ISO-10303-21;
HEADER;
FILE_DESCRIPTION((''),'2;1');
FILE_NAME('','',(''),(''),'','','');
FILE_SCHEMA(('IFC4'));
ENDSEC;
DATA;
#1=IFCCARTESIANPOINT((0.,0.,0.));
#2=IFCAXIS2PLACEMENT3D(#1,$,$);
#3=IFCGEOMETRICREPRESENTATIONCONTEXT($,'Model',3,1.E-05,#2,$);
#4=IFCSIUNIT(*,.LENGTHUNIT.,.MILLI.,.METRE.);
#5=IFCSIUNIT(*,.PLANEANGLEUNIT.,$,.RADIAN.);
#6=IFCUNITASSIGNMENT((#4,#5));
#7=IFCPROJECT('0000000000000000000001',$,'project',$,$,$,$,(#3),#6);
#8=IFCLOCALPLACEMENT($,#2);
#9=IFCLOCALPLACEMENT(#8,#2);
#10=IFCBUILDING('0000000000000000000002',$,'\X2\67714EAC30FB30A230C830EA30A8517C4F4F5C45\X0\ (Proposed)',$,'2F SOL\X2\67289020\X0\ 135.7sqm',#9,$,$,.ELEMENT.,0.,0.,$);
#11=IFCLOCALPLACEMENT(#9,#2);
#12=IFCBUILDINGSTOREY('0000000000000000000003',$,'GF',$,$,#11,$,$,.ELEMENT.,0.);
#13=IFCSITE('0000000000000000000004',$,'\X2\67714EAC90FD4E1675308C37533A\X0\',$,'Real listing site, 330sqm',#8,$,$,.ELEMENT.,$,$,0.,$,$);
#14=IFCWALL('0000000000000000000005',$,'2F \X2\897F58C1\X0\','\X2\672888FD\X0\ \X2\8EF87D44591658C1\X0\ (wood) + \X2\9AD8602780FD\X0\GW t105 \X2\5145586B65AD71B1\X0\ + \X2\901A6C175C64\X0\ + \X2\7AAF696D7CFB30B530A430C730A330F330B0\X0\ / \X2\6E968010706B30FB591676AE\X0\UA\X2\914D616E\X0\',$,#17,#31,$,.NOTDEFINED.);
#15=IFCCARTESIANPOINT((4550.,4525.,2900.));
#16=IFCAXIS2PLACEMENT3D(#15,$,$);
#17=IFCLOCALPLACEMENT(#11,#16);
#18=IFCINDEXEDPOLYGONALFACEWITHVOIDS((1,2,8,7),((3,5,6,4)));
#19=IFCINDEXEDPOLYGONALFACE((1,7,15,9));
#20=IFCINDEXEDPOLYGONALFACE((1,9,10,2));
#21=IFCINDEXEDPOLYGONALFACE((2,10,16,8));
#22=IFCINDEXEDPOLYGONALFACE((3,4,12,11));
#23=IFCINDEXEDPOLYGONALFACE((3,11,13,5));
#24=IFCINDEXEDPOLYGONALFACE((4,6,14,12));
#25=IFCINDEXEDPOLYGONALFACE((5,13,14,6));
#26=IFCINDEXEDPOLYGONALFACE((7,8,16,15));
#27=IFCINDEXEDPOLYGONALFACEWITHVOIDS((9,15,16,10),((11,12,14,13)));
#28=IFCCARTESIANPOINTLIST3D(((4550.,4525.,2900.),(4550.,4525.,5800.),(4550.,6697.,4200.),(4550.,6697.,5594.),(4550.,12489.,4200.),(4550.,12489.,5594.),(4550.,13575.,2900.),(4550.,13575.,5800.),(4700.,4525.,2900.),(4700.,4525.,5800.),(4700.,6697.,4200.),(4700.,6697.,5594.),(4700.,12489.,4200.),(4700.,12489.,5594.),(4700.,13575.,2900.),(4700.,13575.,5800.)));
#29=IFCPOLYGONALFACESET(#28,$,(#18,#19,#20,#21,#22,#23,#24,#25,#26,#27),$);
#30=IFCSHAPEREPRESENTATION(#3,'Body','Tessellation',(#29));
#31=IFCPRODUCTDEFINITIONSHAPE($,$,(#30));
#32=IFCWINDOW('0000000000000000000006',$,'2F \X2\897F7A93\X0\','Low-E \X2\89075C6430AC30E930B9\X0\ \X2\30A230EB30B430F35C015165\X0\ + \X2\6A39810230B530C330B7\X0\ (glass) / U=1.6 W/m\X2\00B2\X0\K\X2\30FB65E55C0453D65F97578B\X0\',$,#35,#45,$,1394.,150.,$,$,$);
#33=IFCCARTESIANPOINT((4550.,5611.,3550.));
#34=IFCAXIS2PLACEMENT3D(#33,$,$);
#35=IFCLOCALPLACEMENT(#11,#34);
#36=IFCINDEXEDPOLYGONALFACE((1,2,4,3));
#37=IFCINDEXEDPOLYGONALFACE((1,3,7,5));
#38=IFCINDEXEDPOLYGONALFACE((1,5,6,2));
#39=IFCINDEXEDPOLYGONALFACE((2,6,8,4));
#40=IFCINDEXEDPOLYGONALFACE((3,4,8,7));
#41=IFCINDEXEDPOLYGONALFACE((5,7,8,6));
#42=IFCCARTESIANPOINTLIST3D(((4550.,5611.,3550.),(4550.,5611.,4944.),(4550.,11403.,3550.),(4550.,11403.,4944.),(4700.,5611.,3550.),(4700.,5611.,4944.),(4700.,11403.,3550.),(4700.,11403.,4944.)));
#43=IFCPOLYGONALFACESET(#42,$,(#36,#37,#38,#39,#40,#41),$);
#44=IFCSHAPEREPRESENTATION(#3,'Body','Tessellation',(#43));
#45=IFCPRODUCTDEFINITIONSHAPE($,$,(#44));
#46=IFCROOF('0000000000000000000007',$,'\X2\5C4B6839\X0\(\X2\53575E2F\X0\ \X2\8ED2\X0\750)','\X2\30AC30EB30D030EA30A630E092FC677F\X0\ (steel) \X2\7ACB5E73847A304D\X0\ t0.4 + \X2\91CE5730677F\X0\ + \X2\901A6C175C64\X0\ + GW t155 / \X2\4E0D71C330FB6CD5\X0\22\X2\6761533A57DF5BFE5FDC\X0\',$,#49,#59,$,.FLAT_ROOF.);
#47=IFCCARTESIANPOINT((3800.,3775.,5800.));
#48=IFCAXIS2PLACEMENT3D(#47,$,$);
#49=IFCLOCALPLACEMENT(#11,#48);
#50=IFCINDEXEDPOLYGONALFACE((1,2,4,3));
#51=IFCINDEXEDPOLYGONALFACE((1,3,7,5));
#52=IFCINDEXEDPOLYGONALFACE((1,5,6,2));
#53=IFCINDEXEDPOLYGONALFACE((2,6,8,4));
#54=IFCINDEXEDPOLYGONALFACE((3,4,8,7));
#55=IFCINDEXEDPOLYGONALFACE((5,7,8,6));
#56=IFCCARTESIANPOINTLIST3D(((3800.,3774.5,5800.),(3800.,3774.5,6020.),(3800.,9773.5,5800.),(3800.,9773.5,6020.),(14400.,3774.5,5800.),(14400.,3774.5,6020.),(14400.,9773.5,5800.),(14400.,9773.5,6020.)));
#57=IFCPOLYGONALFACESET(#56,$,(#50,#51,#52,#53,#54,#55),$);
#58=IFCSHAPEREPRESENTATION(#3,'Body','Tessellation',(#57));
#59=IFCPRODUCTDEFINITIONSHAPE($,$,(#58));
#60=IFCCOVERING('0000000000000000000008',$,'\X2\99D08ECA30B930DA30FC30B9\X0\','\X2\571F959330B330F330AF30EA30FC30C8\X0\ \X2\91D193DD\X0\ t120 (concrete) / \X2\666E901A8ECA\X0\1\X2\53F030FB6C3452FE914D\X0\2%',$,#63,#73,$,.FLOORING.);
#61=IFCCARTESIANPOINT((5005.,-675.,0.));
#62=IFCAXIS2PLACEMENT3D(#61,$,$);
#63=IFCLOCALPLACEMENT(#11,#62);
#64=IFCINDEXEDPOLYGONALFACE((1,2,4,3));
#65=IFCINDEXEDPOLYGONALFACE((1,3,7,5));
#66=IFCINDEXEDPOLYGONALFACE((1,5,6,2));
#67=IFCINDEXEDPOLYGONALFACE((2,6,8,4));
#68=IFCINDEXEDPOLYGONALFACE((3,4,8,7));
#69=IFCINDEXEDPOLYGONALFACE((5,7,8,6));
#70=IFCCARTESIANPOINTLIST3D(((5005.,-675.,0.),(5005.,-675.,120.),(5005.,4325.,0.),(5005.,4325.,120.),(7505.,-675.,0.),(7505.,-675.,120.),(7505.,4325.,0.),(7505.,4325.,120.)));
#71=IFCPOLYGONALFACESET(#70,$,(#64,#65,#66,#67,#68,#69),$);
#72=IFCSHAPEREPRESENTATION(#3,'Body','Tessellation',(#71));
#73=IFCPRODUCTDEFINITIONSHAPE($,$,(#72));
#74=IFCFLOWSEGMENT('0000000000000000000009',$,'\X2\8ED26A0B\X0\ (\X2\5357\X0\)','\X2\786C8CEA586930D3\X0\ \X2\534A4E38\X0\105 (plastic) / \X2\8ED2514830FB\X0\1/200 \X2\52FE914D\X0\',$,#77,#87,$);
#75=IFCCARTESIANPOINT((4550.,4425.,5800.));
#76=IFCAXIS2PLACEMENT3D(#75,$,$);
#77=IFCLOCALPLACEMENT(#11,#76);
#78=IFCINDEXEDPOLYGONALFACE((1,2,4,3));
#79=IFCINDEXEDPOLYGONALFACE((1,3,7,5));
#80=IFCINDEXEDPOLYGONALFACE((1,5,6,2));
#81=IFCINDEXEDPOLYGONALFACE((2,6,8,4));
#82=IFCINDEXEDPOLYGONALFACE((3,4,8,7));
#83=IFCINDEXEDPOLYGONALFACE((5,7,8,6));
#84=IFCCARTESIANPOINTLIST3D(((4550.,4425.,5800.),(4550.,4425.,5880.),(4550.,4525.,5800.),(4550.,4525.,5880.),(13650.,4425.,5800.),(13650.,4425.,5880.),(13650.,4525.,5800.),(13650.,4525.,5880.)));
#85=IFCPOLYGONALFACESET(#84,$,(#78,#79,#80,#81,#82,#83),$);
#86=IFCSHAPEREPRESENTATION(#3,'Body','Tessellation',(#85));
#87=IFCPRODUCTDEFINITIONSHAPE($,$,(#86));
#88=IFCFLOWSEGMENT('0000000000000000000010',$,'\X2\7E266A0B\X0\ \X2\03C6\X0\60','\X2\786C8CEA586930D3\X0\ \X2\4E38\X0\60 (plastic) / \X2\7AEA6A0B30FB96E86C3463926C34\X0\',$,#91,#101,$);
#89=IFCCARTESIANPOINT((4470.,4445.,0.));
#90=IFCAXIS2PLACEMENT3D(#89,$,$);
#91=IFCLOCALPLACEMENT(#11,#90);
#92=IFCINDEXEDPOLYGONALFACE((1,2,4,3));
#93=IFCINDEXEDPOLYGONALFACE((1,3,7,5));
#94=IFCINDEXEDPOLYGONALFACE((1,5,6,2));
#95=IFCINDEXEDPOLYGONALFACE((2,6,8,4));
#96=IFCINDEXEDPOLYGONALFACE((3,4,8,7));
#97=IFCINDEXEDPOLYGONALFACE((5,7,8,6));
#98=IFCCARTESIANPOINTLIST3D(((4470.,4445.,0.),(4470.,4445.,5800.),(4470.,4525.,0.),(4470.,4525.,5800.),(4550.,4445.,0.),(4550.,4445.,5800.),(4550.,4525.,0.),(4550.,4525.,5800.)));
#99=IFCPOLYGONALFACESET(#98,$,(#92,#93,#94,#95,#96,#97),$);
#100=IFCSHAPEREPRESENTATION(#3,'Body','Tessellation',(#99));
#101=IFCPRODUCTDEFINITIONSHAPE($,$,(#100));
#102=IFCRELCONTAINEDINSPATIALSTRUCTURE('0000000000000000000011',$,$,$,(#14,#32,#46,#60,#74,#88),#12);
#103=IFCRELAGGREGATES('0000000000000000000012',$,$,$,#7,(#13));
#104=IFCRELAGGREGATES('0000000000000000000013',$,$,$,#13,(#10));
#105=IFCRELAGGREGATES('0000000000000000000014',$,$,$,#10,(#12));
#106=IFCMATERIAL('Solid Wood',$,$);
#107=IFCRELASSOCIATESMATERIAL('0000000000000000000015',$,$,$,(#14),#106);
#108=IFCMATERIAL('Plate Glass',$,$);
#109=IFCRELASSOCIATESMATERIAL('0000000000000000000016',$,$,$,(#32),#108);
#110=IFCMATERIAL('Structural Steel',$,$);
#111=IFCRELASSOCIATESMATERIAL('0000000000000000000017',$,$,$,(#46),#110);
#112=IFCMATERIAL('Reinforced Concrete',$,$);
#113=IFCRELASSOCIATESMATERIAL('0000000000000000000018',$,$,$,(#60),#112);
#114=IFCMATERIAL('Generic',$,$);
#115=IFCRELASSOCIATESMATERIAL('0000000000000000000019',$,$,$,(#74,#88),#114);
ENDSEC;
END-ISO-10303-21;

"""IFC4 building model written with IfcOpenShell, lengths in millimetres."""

from ifc_helpers import new_model, si_unit, frame, frame_2d, origin, place, context, project, spatial, rectangle, extrude, material, element, fill, save


model = new_model("IFC4")

# Units and contexts
model_context = context("Model", 3, precision=1e-05, world=origin())
ifc_project = project(units=[si_unit("LENGTHUNIT", "METRE", prefix="MILLI"), si_unit("PLANEANGLEUNIT", "RADIAN")], contexts=[model_context])

# Site, building, storey
site_placement = place(None, origin())
site = spatial("IfcSite", under=ifc_project, at=site_placement, Name="東京都世田谷区", ObjectType="Real listing site, 330sqm", CompositionType="ELEMENT", RefElevation=0.0)
building_placement = place(site_placement, origin())
building = spatial("IfcBuilding", under=site, at=building_placement, Name="東京・アトリエ兼住居 (Proposed)", ObjectType="2F SOL木造 135.7sqm", CompositionType="ELEMENT", ElevationOfRefHeight=0.0, ElevationOfTerrain=0.0)
storey_placement = place(building_placement, origin())
storey = spatial("IfcBuildingStorey", under=building, at=storey_placement, Name="GF", CompositionType="ELEMENT", Elevation=0.0)

# Shared definitions
ifc_material_1 = material(Name="Solid Wood")

# Shared definitions
ifc_material_2 = material(Name="Reinforced Concrete")

# Shared definitions
ifc_material_3 = material(Name="Plate Glass")

# Wall, opening, window
wall_1_placement = place(storey_placement, frame((4550.0, 4525.0, 2900.0)))
wall_1 = element("IfcWall", 1, at=wall_1_placement, inside=storey, material=ifc_material_1, Name="2F 西壁", Description="木製 軸組外壁 (wood) + 高性能GW t105 充填断熱 + 通気層 + 窯業系サイディング / 準耐火・外皮UA配慮", PredefinedType="NOTDEFINED", context=model_context, shape_type="SweptSolid", body=[
    extrude(rectangle(XDim=150.0, YDim=9050.0, at=frame_2d((75.0, 4525.0))), frame((4550.0, 4525.0, 2900.0)), (0.0, 0.0, 1.0), 2900.0),
])
opening_1_placement = place(storey_placement, frame((4550.0, 5611.0, 3550.0)))
opening_1 = element("IfcOpeningElement", 2, at=opening_1_placement, cuts=wall_1, PredefinedType="NOTDEFINED", context=model_context, shape_type="SweptSolid", body=[
    extrude(rectangle(XDim=150.0, YDim=5792.0, at=frame_2d((75.0, 2896.0))), frame((4550.0, 5611.0, 3550.0)), (0.0, 0.0, 1.0), 1394.0),
])
window_1_placement = place(storey_placement, frame((4550.0, 5611.0, 3550.0)))
window_1 = element("IfcWindow", 3, at=window_1_placement, inside=storey, material=ifc_material_3, Name="2F 西窓", Description="Low-E 複層ガラス アルゴン封入 + 樹脂サッシ (glass) / U=1.6 W/m²K・日射取得型", OverallHeight=1394.0, OverallWidth=150.0, context=model_context, shape_type="SweptSolid", body=[
    extrude(rectangle(XDim=150.0, YDim=5792.0, at=frame_2d((75.0, 2896.0))), frame((4550.0, 5611.0, 3550.0)), (0.0, 0.0, 1.0), 1394.0),
])
fill(opening_1, window_1)

# Roof
ifc_material_4 = material(Name="Structural Steel")
for number, where, name in (
    (4, (3800.0, 3775.0, 5800.0), "屋根(南帯 軒750)"),
):
    element("IfcRoof", number, at=place(storey_placement, frame(where)), inside=storey, material=ifc_material_4, Name=name, Description="ガルバリウム鋼板 (steel) 立平葺き t0.4 + 野地板 + 通気層 + GW t155 / 不燃・法22条区域対応", PredefinedType="FLAT_ROOF", context=model_context, shape_type="SweptSolid", body=[
        extrude(rectangle(XDim=10600.0, YDim=5999.0, at=frame_2d((5300.0, 2999.0))), frame((3800.0, 3775.0, 5800.0)), (0.0, 0.0, 1.0), 220.0),
    ])

# Covering
covering_placement = place(storey_placement, frame((5005.0, -675.0, 0.0)))
element("IfcCovering", 5, at=covering_placement, inside=storey, material=ifc_material_2, Name="駐車スペース", Description="土間コンクリート 金鏝 t120 (concrete) / 普通車1台・水勾配2%", PredefinedType="FLOORING", context=model_context, shape_type="SweptSolid", body=[
    extrude(rectangle(XDim=2500.0, YDim=5000.0, at=frame_2d((1250.0, 2500.0))), frame((5005.0, -675.0, 0.0)), (0.0, 0.0, 1.0), 120.0),
])

# Flow segments
ifc_material_5 = material(Name="Generic")
flow_segment_1_placement = place(storey_placement, frame((4550.0, 4425.0, 5800.0)))
element("IfcFlowSegment", 6, at=flow_segment_1_placement, inside=storey, material=ifc_material_5, Name="軒樋 (南)", Description="硬質塩ビ 半丸105 (plastic) / 軒先・1/200 勾配", context=model_context, shape_type="SweptSolid", body=[
    extrude(rectangle(XDim=9100.0, YDim=100.0, at=frame_2d((4550.0, 50.0))), frame((4550.0, 4425.0, 5800.0)), (0.0, 0.0, 1.0), 80.0),
])
flow_segment_2_placement = place(storey_placement, frame((4470.0, 4445.0, 0.0)))
element("IfcFlowSegment", 7, at=flow_segment_2_placement, inside=storey, material=ifc_material_5, Name="縦樋 φ60", Description="硬質塩ビ 丸60 (plastic) / 竪樋・雨水排水", context=model_context, shape_type="SweptSolid", body=[
    extrude(rectangle(XDim=80.0, YDim=80.0, at=frame_2d((40.0, 40.0))), frame((4470.0, 4445.0, 0.0)), (0.0, 0.0, 1.0), 5800.0),
])

save(model, "model.ifc")
